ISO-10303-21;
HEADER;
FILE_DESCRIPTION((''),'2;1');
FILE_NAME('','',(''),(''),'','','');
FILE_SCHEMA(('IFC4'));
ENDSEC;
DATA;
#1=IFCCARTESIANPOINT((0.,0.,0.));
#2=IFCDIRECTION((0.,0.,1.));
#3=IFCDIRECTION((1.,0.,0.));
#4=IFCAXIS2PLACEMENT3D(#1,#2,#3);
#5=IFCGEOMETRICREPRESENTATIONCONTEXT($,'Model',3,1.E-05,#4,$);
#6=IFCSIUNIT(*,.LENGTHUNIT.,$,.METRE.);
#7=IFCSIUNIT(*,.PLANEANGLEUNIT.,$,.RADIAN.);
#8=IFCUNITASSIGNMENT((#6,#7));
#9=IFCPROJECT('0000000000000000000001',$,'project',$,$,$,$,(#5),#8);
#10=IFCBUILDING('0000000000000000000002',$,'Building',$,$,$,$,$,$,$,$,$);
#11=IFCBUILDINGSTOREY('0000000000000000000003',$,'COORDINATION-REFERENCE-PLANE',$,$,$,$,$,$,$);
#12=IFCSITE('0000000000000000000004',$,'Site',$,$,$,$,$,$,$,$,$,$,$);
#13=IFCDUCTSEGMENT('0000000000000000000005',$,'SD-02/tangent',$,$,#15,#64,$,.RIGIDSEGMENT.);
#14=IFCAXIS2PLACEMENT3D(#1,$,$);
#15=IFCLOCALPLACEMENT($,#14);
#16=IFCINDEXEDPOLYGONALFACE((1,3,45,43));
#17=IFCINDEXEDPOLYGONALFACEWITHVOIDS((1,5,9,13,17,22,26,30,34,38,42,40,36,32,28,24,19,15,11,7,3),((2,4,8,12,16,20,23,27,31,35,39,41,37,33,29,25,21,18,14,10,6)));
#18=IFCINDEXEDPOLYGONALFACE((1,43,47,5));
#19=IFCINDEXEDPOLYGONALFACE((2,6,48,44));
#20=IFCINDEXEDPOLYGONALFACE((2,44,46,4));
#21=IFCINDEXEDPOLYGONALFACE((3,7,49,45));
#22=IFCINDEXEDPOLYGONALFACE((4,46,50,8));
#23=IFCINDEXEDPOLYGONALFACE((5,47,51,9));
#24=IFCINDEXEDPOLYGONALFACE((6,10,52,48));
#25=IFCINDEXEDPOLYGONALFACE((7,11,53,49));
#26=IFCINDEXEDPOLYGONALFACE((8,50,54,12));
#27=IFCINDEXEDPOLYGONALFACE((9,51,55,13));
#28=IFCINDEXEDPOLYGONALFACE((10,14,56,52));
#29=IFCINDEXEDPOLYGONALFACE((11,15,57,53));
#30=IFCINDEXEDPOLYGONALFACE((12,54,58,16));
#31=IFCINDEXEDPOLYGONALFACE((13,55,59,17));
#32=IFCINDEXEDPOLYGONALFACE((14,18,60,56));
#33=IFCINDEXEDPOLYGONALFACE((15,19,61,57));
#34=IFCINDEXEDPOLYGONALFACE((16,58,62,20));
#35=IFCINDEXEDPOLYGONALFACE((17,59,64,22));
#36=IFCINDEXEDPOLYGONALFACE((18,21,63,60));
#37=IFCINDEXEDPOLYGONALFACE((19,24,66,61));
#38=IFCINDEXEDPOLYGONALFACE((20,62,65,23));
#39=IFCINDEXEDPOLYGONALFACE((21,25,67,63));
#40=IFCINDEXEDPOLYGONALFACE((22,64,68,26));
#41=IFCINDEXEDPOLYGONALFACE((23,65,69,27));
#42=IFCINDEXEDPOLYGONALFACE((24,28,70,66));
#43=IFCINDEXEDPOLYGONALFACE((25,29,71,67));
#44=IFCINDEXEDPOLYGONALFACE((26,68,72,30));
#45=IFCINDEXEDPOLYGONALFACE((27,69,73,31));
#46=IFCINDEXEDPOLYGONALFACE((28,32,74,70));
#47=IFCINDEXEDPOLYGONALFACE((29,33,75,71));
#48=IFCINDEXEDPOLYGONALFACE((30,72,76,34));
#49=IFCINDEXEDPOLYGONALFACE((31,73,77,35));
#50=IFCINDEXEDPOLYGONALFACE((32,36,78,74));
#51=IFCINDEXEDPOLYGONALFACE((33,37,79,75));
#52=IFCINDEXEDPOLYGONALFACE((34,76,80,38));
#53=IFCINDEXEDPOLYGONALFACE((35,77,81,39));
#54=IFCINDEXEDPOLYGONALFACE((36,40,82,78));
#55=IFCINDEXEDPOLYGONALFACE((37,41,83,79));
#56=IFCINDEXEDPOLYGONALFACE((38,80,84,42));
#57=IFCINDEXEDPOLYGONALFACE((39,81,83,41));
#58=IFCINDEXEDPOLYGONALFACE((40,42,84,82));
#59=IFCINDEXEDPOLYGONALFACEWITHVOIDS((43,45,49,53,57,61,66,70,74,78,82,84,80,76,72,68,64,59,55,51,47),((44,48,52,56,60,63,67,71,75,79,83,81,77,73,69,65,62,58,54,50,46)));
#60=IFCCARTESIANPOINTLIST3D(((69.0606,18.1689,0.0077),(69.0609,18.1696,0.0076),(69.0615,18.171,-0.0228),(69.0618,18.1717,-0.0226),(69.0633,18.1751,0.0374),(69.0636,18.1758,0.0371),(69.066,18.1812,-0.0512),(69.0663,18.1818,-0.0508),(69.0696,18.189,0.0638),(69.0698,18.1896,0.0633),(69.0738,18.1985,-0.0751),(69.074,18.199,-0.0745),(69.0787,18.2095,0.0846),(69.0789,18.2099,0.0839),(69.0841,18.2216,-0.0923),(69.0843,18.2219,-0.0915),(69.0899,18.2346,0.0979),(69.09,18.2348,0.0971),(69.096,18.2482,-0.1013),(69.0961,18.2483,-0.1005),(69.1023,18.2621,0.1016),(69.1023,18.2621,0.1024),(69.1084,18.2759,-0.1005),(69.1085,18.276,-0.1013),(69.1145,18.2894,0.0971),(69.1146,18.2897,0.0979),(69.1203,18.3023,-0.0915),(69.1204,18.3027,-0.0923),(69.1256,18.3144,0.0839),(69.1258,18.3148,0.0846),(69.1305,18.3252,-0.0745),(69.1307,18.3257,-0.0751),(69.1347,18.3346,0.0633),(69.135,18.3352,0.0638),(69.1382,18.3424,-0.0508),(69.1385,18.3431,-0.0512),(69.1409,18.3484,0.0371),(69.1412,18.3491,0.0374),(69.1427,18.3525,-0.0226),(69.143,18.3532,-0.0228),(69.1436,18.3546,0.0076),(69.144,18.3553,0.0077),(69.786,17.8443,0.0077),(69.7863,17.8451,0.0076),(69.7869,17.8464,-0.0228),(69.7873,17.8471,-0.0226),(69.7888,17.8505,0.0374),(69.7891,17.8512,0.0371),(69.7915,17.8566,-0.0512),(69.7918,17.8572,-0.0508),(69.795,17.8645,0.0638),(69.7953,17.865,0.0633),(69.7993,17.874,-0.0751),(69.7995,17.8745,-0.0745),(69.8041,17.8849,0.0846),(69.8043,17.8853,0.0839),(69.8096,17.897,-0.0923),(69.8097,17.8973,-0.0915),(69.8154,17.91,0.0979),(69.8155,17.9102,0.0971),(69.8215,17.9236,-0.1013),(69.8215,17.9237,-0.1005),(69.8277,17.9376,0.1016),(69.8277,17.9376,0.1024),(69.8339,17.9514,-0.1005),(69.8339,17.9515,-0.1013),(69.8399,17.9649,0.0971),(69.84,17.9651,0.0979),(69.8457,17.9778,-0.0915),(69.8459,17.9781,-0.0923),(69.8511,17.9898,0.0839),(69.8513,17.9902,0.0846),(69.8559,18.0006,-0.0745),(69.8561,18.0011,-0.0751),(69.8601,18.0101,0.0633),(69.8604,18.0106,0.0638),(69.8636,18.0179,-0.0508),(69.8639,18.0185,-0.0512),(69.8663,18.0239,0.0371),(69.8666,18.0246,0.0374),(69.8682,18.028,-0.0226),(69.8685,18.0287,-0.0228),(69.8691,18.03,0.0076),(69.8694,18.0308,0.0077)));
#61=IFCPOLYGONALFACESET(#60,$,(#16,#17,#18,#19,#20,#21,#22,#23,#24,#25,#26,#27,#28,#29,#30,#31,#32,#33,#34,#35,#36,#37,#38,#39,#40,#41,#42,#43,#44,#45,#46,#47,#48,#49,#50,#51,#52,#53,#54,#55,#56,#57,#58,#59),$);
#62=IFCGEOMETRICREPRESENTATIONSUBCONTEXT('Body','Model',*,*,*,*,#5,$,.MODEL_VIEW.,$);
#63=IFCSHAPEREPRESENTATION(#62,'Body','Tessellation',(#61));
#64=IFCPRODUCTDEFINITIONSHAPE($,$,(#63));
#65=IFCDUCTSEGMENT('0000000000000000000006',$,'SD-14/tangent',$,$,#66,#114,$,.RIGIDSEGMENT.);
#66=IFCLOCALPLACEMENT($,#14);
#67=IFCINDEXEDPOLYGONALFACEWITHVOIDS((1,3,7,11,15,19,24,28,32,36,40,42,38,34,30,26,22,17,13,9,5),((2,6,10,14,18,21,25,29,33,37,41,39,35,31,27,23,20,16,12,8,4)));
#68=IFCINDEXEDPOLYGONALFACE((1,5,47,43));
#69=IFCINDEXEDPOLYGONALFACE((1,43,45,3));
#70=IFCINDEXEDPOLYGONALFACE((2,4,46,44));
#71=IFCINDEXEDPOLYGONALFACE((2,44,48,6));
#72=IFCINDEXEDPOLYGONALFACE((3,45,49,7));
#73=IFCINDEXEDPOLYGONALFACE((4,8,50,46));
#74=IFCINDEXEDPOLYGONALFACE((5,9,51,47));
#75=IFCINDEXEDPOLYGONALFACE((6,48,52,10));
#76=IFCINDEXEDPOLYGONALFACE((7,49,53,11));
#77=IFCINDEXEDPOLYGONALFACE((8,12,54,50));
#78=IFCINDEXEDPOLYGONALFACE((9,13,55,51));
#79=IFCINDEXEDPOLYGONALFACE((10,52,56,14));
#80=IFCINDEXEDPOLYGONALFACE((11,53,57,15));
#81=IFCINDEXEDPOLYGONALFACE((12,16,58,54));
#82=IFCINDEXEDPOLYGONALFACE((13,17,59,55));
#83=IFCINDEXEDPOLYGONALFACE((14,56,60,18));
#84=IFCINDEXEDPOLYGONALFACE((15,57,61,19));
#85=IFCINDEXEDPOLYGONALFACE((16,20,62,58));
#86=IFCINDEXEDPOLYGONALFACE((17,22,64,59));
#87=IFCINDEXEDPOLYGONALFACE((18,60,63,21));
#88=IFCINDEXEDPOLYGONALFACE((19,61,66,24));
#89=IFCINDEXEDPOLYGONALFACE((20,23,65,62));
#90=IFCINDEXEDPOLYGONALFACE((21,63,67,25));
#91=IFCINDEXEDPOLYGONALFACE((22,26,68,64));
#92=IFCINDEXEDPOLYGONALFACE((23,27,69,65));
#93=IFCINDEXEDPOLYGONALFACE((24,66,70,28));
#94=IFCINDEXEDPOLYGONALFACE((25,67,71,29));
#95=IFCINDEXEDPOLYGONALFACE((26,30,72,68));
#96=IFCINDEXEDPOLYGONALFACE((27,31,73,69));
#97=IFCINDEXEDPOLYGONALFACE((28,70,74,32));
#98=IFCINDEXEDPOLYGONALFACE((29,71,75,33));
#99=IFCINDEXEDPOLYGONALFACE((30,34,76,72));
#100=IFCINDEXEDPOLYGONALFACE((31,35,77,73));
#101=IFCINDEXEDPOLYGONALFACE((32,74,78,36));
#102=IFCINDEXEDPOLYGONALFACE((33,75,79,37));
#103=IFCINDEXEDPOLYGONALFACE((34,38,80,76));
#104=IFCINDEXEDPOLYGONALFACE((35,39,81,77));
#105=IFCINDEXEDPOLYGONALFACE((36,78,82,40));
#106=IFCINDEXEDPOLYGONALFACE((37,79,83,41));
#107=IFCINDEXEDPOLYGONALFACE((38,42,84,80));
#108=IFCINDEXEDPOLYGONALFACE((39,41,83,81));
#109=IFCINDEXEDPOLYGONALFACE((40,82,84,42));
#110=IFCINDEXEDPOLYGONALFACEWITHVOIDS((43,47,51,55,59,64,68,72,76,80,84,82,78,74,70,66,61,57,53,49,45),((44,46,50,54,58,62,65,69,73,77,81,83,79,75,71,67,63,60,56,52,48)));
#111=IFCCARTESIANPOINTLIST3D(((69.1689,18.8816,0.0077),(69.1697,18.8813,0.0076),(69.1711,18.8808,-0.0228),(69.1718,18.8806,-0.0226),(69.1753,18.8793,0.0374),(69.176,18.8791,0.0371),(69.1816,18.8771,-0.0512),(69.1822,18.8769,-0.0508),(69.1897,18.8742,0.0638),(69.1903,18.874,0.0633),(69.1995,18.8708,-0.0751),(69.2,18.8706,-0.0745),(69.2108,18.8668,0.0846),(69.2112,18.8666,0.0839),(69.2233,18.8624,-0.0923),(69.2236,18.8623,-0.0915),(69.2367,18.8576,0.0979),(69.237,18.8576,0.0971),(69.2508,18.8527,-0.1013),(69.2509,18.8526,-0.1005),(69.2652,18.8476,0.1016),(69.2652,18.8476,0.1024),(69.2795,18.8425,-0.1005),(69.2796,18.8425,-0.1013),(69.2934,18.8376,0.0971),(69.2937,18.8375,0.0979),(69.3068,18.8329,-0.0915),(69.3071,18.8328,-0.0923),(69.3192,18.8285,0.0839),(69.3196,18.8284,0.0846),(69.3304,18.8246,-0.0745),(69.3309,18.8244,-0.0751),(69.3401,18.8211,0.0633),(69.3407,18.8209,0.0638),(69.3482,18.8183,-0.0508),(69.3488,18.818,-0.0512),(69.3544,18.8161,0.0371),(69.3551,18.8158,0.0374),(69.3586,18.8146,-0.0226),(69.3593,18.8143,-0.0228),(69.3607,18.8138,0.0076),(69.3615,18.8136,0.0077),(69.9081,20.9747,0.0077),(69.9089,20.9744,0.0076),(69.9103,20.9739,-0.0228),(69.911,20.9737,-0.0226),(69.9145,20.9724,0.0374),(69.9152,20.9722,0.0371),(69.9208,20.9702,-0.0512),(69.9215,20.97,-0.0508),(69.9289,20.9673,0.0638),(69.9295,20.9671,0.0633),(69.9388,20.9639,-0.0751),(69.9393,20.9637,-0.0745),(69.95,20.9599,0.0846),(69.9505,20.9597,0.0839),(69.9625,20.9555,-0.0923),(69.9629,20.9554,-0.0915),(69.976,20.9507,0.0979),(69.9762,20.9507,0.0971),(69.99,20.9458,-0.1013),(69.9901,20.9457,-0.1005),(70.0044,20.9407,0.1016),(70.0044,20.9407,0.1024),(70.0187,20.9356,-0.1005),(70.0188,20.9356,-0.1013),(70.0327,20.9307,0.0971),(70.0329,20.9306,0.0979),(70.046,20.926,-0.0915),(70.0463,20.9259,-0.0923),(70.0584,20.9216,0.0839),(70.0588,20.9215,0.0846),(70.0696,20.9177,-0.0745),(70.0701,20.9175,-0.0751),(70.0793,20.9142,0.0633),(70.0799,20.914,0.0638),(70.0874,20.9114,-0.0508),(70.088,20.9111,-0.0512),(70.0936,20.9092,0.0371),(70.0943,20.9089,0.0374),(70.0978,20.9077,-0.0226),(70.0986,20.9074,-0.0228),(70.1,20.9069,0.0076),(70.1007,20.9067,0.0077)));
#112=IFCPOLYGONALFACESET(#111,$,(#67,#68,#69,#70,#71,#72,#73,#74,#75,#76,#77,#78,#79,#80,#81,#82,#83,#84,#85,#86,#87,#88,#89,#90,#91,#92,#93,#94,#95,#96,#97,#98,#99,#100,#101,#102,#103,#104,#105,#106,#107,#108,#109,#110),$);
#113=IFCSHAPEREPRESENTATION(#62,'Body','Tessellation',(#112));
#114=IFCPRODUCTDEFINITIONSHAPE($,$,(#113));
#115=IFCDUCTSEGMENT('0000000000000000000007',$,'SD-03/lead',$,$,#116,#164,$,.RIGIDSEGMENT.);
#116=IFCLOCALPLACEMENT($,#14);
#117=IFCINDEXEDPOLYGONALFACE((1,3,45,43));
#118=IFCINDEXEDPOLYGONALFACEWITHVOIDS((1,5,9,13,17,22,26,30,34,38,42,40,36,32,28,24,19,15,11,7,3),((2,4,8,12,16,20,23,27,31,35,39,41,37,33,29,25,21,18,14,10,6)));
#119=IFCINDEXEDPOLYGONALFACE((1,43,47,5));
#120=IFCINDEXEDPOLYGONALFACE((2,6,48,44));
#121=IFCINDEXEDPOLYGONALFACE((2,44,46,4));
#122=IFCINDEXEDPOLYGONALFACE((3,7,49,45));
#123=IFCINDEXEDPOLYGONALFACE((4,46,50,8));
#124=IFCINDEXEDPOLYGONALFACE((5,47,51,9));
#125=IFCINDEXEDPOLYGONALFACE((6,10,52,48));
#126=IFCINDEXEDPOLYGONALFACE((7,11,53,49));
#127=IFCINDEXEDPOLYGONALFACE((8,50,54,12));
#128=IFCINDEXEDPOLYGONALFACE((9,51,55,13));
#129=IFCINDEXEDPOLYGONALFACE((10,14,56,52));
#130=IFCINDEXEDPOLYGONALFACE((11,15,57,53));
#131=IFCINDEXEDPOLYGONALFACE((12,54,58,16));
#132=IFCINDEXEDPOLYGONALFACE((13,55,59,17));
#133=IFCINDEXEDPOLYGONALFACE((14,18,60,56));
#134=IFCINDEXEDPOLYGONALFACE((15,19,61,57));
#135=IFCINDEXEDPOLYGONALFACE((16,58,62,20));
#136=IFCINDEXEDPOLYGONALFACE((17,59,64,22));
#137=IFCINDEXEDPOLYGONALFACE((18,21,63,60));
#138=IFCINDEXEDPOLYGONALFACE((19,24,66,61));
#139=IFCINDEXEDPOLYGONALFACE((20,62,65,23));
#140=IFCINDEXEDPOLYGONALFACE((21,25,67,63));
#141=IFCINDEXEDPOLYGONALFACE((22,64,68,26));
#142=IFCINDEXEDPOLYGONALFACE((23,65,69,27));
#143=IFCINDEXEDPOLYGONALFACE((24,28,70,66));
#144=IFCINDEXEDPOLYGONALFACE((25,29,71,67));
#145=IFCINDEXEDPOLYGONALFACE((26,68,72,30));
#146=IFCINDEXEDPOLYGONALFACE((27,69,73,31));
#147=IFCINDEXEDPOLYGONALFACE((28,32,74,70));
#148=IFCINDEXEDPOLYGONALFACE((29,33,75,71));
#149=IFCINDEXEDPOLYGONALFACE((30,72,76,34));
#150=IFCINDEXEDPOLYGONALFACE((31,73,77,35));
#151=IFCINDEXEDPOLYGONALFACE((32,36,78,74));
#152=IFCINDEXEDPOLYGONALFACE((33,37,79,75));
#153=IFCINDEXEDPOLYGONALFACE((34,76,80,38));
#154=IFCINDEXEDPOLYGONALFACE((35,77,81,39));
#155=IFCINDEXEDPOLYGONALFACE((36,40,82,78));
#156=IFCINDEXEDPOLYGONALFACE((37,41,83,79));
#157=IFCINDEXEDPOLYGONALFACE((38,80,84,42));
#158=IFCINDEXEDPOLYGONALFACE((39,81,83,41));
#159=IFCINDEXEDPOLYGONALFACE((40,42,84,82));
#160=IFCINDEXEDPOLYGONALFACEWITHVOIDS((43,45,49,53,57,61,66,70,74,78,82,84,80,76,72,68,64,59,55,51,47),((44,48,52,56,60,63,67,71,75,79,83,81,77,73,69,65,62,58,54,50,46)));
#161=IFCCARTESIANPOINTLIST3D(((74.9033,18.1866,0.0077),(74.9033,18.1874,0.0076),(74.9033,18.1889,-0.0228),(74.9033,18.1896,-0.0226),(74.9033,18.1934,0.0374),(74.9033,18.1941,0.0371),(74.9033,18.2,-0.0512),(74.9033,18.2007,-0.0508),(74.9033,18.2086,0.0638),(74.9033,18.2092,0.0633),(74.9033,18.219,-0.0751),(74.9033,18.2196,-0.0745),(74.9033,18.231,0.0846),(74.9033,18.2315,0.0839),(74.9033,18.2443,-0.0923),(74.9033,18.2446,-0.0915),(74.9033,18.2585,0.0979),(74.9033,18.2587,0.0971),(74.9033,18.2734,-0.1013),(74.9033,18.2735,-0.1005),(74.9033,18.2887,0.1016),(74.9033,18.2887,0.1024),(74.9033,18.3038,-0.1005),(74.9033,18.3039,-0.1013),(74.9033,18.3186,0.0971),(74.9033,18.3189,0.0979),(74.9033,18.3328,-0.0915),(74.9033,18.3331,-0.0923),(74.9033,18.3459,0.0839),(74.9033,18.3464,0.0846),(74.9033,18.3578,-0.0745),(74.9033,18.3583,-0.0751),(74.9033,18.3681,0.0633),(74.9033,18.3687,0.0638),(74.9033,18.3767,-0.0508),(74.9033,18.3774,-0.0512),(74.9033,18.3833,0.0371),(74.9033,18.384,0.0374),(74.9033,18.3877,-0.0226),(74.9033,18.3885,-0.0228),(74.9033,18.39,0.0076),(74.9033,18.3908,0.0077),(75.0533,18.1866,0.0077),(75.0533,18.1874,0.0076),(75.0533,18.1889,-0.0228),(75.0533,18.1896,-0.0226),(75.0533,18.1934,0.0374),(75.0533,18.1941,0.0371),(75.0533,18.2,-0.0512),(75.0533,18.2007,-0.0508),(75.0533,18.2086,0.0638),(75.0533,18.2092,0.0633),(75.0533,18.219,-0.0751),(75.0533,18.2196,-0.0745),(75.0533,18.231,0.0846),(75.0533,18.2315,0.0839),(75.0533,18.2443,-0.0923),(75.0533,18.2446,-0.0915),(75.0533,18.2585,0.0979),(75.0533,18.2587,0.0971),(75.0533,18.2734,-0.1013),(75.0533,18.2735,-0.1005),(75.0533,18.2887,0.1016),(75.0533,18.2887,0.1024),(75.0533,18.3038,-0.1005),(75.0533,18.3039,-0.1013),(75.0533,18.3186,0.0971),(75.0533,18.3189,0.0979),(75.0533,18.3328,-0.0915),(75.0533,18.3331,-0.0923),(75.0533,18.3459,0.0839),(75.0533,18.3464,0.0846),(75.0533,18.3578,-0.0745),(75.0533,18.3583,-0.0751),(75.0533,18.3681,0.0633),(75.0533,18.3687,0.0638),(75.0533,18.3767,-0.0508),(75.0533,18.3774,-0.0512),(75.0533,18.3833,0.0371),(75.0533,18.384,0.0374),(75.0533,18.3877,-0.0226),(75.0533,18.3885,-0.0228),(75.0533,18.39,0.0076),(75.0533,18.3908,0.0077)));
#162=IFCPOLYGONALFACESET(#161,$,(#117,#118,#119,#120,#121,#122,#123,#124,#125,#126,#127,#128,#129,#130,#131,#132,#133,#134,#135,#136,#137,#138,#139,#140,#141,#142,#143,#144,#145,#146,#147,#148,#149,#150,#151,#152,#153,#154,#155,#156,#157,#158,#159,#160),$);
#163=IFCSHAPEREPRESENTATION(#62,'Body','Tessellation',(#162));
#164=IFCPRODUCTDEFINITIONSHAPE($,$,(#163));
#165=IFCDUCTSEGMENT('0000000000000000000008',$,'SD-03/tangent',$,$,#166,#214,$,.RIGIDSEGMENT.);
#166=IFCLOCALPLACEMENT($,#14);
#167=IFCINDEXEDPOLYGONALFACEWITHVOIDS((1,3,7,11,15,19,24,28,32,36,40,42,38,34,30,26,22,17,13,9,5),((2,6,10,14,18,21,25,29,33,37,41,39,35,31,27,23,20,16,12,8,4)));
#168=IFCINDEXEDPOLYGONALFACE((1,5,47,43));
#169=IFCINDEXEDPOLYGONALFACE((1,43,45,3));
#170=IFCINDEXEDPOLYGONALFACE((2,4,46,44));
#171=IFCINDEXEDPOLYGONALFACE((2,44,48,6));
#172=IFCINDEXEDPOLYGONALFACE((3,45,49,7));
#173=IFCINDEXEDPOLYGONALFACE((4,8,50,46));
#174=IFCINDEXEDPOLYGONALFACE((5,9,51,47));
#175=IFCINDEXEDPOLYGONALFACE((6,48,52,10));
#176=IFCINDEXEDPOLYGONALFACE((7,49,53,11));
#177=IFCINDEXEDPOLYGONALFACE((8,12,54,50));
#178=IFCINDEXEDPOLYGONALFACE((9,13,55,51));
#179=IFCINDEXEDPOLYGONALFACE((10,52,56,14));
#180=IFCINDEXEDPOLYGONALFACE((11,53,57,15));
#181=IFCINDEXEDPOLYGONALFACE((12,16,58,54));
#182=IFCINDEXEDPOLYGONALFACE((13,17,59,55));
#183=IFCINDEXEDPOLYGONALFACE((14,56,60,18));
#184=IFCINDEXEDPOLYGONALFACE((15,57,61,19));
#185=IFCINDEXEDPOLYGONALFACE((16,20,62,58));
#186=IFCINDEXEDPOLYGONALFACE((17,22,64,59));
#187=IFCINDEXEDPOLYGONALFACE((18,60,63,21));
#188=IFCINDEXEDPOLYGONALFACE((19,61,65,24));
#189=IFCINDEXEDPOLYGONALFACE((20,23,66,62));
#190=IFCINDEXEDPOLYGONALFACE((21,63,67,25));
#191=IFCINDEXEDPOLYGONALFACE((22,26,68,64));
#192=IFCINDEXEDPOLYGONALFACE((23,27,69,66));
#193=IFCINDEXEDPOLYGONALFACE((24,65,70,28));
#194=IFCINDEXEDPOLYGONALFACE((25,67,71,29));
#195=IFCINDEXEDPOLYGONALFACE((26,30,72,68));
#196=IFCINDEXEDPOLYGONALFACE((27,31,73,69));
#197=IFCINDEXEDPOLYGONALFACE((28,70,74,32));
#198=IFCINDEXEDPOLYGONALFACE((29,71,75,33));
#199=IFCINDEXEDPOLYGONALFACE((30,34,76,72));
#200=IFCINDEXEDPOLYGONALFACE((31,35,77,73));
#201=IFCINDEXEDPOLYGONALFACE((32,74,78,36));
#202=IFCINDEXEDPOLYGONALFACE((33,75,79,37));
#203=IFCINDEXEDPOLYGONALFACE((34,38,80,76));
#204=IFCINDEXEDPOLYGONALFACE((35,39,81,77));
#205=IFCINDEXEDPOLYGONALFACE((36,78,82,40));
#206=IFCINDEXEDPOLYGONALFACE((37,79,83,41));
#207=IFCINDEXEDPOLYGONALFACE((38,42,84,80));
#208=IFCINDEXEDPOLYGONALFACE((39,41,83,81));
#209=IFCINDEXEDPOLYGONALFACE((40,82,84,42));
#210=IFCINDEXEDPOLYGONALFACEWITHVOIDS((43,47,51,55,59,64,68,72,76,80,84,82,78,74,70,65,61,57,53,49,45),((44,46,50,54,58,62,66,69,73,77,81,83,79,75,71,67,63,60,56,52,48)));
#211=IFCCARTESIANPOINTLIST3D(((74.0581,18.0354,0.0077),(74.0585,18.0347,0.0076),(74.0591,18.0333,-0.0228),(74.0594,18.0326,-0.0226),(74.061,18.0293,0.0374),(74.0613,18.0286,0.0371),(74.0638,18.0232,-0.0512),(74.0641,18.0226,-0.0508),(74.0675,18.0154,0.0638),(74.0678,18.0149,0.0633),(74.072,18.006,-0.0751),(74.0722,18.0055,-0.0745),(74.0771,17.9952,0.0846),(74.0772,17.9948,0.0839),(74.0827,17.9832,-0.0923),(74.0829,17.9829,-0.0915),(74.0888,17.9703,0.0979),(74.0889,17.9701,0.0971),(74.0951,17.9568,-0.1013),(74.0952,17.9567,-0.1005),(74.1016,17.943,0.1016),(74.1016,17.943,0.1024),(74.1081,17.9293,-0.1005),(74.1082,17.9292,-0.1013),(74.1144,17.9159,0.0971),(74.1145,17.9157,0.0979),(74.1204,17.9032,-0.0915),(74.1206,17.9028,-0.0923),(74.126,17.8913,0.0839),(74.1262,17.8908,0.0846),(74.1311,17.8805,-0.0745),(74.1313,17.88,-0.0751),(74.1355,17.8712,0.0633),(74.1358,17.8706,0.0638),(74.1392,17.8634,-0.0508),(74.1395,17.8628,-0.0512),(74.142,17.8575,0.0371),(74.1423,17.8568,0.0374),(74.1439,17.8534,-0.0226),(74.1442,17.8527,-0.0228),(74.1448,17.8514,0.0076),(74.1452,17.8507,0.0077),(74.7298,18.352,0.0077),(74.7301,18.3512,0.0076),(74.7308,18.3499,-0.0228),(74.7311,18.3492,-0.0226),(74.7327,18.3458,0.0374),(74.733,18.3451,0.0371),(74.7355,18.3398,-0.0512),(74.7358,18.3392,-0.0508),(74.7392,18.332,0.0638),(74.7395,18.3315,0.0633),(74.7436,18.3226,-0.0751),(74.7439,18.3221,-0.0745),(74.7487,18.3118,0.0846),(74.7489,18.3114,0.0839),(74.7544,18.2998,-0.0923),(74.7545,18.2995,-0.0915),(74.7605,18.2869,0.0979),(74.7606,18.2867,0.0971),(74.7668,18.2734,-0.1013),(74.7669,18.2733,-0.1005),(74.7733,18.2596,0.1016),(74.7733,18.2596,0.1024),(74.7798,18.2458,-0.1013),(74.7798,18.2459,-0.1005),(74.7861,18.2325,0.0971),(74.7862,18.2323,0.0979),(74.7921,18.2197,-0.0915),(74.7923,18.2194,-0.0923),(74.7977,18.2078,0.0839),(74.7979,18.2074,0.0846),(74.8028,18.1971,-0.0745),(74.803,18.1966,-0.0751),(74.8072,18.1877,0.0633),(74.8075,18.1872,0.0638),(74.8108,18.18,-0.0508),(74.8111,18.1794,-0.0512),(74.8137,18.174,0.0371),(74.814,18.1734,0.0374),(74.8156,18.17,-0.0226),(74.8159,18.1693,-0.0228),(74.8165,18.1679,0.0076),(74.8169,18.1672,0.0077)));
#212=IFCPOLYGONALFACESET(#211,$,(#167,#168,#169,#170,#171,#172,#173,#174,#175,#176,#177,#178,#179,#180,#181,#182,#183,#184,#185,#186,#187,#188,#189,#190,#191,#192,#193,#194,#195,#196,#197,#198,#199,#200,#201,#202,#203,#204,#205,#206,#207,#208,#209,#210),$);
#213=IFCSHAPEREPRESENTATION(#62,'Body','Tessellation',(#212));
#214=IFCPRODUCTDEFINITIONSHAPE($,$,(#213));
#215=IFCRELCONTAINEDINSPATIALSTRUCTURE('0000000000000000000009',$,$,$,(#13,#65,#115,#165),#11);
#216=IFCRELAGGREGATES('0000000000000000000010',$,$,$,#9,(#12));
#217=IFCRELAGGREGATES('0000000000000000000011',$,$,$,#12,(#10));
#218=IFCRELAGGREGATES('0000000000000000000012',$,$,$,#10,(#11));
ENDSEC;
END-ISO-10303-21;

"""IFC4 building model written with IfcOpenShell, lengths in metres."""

from ifc_helpers import new_model, si_unit, frame, origin_with_axes, place, context, subcontext, project, spatial, hollow_circle, extrude, element, save


model = new_model("IFC4")

# Units and contexts
model_context_1 = context("Model", 3, precision=1e-05, world=origin_with_axes())
body_context_1 = subcontext(model_context_1, "Body", "Model", "MODEL_VIEW")
ifc_project = project(units=[si_unit("LENGTHUNIT", "METRE"), si_unit("PLANEANGLEUNIT", "RADIAN")], contexts=[model_context_1])

# Site, building, storey
site = spatial("IfcSite", under=ifc_project, Name="Site")
building = spatial("IfcBuilding", under=site, Name="Building")
storey = spatial("IfcBuildingStorey", under=building, Name="COORDINATION-REFERENCE-PLANE")

# Duct segment
duct_segment_1_placement = place(None, frame((69.1023, 18.2621, 0.0), z_axis=(0.912813, -0.408378, 0.0), x_axis=(0.0, 0.0, 1.0)))
element("IfcDuctSegment", 1, at=duct_segment_1_placement, inside=storey, Name="SD-02/tangent", PredefinedType="RIGIDSEGMENT", context=body_context_1, shape_type="SweptSolid", body=[
    extrude(hollow_circle(Radius=0.1024, WallThickness=0.0008), origin_with_axes(), (0.0, 0.0, 1.0), 0.7947),
])

# Duct segment
duct_segment_2_placement = place(None, frame((69.2652, 18.8476, 0.0), z_axis=(0.333018, 0.94292, 0.0), x_axis=(0.0, 0.0, 1.0)))
element("IfcDuctSegment", 2, at=duct_segment_2_placement, inside=storey, Name="SD-14/tangent", PredefinedType="RIGIDSEGMENT", context=body_context_1, shape_type="SweptSolid", body=[
    extrude(hollow_circle(Radius=0.1024, WallThickness=0.0008), origin_with_axes(), (0.0, 0.0, 1.0), 2.2198),
])

# Duct segment
duct_segment_3_placement = place(None, frame((75.0533, 18.2887, 0.0), z_axis=(-1.0, 0.0, 0.0), x_axis=(0.0, 0.0, 1.0)))
element("IfcDuctSegment", 3, at=duct_segment_3_placement, inside=storey, Name="SD-03/lead", PredefinedType="RIGIDSEGMENT", context=body_context_1, shape_type="SweptSolid", body=[
    extrude(hollow_circle(Radius=0.1024, WallThickness=0.0008), origin_with_axes(), (0.0, 0.0, 1.0), 0.15),
])

# Duct segment
duct_segment_4_placement = place(None, frame((74.7733, 18.2596, 0.0), z_axis=(-0.904569, -0.426327, 0.0), x_axis=(0.0, 0.0, 1.0)))
element("IfcDuctSegment", 4, at=duct_segment_4_placement, inside=storey, Name="SD-03/tangent", PredefinedType="RIGIDSEGMENT", context=body_context_1, shape_type="SweptSolid", body=[
    extrude(hollow_circle(Radius=0.1024, WallThickness=0.0008), origin_with_axes(), (0.0, 0.0, 1.0), 0.7425),
])

save(model, "model.ifc")
